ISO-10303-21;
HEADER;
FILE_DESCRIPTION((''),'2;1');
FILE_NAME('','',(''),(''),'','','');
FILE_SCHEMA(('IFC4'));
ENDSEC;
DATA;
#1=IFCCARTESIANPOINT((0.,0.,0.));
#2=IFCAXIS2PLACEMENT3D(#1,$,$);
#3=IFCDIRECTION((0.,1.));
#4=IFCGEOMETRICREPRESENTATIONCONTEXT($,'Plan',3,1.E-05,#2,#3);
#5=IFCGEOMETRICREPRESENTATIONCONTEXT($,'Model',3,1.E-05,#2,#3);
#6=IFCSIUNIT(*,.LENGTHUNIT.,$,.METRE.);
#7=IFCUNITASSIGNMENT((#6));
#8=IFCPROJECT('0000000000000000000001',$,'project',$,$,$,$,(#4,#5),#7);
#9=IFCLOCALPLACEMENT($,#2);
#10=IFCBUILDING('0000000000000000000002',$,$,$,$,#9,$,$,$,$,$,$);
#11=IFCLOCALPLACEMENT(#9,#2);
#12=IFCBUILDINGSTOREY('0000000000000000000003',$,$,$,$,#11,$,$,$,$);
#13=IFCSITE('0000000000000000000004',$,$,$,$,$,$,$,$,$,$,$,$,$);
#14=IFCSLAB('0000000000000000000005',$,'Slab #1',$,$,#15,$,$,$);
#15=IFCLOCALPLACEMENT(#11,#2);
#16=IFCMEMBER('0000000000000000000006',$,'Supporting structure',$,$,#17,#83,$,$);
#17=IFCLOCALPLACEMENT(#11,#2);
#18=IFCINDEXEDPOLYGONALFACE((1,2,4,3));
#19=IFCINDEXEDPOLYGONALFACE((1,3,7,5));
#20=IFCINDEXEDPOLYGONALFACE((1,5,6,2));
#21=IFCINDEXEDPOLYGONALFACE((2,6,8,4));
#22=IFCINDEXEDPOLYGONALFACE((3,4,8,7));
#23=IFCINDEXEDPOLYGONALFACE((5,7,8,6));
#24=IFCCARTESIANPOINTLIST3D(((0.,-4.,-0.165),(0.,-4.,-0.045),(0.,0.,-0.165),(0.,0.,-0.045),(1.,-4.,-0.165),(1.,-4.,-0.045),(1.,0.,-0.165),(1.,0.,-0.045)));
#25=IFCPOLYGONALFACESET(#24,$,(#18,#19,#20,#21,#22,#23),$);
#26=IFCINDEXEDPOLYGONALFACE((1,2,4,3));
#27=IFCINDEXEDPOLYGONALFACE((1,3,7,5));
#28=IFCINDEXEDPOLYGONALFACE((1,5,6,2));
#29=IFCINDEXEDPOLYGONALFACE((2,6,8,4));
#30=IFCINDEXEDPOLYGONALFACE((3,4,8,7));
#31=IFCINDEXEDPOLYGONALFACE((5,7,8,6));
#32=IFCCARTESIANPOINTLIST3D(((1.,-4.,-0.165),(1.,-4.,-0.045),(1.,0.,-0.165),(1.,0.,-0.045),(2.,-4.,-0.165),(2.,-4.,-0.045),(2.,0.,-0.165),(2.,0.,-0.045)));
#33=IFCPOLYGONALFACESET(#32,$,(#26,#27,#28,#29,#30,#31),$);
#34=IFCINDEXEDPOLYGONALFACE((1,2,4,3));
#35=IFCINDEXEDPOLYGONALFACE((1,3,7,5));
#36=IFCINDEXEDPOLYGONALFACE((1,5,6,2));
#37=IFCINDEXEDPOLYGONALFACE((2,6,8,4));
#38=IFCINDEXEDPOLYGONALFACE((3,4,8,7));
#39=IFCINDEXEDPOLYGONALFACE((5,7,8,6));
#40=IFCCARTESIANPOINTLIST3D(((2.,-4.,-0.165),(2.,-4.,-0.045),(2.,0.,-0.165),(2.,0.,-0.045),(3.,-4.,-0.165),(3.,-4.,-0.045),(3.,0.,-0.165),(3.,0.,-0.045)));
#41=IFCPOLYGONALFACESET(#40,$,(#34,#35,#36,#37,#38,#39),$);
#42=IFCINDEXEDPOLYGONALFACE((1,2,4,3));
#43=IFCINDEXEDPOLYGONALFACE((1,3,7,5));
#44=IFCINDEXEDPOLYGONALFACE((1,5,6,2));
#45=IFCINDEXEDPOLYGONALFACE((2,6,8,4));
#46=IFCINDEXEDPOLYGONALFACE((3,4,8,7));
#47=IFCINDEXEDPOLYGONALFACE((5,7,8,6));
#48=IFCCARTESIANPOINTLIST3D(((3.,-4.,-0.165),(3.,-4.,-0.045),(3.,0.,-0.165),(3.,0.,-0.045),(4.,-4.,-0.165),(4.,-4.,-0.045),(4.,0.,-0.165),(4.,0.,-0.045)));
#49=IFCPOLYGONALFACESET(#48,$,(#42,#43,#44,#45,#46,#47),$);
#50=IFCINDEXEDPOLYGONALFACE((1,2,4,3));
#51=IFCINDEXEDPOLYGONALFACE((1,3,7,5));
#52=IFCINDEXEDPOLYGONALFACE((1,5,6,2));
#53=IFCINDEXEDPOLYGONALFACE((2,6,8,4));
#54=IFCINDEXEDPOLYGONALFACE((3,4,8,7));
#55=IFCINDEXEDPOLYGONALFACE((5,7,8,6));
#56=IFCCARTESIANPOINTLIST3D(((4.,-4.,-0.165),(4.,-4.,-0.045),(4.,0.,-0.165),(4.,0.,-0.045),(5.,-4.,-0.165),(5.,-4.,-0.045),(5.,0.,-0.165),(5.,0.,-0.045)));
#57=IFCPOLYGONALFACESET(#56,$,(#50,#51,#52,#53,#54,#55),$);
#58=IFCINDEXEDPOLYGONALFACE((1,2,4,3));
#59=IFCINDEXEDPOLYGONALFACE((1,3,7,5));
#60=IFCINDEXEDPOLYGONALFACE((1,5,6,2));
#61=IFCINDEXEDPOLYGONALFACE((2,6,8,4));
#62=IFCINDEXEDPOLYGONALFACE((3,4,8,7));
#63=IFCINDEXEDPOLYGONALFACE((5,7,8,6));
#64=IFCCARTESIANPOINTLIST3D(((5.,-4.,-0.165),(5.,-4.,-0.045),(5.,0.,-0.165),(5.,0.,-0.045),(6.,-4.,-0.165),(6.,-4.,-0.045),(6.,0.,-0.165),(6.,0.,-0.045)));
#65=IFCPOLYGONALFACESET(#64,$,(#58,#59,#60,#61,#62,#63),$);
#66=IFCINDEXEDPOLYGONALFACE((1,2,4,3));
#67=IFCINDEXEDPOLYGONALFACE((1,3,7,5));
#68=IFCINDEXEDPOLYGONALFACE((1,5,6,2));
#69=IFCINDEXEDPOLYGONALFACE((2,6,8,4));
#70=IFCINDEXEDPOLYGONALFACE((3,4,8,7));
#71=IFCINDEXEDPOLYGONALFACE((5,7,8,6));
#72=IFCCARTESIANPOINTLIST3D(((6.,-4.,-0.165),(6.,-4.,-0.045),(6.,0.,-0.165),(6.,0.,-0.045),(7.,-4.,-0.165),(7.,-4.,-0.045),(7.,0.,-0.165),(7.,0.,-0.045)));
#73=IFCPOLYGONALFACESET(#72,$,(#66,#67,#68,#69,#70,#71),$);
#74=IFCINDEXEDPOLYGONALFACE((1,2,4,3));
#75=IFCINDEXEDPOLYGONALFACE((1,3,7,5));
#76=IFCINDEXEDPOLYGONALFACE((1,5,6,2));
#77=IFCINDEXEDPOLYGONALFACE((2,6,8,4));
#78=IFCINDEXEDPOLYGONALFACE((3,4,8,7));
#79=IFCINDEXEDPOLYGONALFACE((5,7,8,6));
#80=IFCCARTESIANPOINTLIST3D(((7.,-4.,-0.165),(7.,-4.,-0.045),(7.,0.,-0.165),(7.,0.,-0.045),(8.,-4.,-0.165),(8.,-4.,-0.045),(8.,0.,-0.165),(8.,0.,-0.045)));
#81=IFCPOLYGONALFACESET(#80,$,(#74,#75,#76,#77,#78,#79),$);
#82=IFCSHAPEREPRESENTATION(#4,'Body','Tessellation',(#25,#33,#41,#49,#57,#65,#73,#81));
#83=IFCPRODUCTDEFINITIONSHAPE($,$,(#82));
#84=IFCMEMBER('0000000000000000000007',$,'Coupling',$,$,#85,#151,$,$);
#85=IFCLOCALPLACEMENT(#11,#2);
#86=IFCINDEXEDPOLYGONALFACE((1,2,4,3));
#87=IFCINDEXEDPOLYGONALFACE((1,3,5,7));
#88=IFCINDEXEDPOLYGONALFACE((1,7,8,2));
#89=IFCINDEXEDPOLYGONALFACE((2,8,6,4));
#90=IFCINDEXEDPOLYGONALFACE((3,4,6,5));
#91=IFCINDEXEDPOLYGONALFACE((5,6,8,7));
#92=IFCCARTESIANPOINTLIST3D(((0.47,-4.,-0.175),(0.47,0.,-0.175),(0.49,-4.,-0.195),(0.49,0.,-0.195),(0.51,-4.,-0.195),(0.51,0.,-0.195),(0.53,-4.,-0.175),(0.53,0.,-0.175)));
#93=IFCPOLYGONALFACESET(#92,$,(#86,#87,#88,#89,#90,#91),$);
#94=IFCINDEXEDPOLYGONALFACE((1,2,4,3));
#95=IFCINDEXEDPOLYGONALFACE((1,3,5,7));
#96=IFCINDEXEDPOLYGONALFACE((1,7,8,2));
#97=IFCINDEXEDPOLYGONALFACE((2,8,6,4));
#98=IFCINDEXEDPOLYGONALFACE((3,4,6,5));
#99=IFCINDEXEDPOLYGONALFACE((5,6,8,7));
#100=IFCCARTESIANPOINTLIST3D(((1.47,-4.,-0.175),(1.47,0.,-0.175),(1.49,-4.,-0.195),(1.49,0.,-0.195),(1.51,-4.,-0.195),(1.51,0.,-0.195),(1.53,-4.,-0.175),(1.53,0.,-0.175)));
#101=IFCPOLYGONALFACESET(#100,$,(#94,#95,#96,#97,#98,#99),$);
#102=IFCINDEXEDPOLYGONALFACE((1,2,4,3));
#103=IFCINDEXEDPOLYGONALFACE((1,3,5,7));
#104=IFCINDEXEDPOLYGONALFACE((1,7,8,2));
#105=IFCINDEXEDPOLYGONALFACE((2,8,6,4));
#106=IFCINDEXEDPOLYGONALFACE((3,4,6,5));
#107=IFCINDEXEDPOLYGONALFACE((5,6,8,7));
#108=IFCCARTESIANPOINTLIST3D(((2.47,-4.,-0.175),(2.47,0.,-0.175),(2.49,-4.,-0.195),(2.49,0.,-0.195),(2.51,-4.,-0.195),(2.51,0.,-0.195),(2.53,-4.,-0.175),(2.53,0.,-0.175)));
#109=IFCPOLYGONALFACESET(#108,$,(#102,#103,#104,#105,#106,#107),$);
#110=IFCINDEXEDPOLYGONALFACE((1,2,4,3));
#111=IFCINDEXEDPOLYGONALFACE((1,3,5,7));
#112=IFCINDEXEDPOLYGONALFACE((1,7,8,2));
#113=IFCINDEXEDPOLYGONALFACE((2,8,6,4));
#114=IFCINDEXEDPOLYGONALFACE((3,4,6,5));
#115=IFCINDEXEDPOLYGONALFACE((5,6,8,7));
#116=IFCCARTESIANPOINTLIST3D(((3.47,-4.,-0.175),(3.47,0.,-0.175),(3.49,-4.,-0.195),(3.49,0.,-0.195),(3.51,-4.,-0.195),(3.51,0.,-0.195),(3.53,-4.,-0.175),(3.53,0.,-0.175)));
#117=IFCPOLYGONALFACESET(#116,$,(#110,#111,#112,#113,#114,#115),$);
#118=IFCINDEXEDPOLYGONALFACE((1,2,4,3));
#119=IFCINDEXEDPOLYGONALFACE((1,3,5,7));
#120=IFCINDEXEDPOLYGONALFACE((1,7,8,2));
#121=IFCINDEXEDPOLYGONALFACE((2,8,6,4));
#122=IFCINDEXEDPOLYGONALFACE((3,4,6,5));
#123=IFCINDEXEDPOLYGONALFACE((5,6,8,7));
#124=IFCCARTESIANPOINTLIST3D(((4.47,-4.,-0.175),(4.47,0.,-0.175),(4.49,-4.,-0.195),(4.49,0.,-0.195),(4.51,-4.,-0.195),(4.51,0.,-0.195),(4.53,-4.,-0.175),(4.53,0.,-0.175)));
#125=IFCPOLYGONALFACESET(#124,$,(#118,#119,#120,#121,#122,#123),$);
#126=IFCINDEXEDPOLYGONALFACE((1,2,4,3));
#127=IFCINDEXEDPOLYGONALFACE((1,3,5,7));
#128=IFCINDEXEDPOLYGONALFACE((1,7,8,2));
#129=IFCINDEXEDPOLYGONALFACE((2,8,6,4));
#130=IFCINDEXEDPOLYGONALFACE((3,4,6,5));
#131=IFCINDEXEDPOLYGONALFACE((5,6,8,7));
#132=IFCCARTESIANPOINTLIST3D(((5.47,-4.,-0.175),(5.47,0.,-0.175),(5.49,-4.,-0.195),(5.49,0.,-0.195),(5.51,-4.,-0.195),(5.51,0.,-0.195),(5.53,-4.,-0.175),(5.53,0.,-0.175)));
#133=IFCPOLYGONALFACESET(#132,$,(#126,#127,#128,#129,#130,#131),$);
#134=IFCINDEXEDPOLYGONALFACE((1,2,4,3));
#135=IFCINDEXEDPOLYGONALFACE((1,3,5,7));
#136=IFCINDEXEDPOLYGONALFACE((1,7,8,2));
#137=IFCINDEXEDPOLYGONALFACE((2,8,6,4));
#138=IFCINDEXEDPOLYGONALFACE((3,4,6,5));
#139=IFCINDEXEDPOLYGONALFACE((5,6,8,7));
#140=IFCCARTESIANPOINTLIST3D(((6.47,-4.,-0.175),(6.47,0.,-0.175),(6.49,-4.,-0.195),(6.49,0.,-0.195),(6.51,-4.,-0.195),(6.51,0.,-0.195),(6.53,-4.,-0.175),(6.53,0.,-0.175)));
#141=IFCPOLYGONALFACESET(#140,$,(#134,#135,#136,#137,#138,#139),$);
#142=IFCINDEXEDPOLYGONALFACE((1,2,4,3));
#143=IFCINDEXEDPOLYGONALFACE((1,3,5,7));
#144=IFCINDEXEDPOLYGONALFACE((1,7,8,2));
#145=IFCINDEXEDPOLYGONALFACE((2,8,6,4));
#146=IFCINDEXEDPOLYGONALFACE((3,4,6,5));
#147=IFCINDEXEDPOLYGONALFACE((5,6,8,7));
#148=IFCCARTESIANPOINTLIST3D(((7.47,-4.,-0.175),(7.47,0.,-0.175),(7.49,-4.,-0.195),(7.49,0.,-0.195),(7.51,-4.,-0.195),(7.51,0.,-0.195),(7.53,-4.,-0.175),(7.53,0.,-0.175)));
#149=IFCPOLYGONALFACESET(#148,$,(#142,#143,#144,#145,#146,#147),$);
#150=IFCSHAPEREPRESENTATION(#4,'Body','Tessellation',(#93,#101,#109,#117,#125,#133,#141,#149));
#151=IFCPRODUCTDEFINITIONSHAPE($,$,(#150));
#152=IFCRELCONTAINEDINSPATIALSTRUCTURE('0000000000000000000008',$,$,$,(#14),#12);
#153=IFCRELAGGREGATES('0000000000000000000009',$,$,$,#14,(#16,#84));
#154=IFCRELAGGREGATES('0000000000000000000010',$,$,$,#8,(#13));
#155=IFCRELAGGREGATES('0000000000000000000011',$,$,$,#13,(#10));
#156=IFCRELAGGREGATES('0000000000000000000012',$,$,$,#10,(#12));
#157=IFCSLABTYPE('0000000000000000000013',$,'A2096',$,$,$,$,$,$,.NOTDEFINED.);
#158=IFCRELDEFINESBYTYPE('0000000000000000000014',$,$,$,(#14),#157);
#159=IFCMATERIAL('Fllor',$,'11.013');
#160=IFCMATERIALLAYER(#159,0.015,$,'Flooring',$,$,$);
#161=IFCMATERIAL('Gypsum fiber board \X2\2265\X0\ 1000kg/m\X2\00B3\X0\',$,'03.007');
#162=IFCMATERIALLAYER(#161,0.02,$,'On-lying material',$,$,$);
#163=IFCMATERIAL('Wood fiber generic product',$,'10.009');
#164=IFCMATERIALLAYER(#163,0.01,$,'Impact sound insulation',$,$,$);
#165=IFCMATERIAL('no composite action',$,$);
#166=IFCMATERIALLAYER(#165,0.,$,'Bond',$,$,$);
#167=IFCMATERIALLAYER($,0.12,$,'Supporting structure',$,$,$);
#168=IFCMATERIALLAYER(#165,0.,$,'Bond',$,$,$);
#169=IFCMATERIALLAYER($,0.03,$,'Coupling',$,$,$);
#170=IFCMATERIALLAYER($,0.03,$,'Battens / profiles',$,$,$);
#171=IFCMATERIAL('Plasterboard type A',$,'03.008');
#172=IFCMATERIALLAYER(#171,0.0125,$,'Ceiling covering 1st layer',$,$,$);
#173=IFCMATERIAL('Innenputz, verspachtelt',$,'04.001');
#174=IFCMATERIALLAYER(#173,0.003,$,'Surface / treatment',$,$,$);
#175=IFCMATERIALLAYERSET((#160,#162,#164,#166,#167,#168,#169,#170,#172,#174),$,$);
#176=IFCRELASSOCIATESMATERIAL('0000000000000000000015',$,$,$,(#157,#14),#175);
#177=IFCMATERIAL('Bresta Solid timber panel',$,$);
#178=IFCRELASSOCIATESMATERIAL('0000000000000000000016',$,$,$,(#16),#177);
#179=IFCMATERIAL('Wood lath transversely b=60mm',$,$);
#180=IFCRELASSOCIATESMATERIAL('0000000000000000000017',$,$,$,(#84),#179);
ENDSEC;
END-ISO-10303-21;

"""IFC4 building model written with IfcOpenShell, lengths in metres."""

from ifc_helpers import new_model, si_unit, direction, frame, frame_2d, origin, place, context, project, spatial, polyline, rectangle, outline, extrude, material, layer, layer_set, type_object, element, aggregate, save


model = new_model("IFC4")

# Units and contexts
plan_context = context("Plan", 3, precision=1e-05, world=origin(), true_north=direction((0.0, 1.0)))
model_context = context("Model", 3, precision=1e-05, world=origin(), true_north=direction((0.0, 1.0)))
ifc_project = project(units=[si_unit("LENGTHUNIT", "METRE")], contexts=[plan_context, model_context])

# Site, building, storey
site = spatial("IfcSite", under=ifc_project)
building_placement = place(None, origin())
building = spatial("IfcBuilding", under=site, at=building_placement)
storey_placement = place(building_placement, origin())
storey = spatial("IfcBuildingStorey", under=building, at=storey_placement)

# Slab, members
ifc_material_1 = material(Name="Fllor", Category="11.013")
ifc_layer_1 = layer(ifc_material_1, 0.015, Name="Flooring")
ifc_material_2 = material(Name="Gypsum fiber board ≥ 1000kg/m³", Category="03.007")
ifc_layer_2 = layer(ifc_material_2, 0.02, Name="On-lying material")
ifc_material_3 = material(Name="Wood fiber generic product", Category="10.009")
ifc_layer_3 = layer(ifc_material_3, 0.01, Name="Impact sound insulation")
ifc_material_4 = material(Name="no composite action")
ifc_layer_4 = layer(ifc_material_4, 0.0, Name="Bond")
ifc_layer_5 = layer(None, 0.12, Name="Supporting structure")
ifc_layer_6 = layer(ifc_material_4, 0.0, Name="Bond")
ifc_layer_7 = layer(None, 0.03, Name="Coupling")
ifc_layer_8 = layer(None, 0.03, Name="Battens / profiles")
ifc_material_5 = material(Name="Plasterboard type A", Category="03.008")
ifc_layer_9 = layer(ifc_material_5, 0.0125, Name="Ceiling covering 1st layer")
ifc_material_6 = material(Name="Innenputz, verspachtelt", Category="04.001")
ifc_layer_10 = layer(ifc_material_6, 0.003, Name="Surface / treatment")
ifc_layer_set = layer_set([ifc_layer_1, ifc_layer_2, ifc_layer_3, ifc_layer_4, ifc_layer_5, ifc_layer_6, ifc_layer_7, ifc_layer_8, ifc_layer_9, ifc_layer_10])
slab_type = type_object("IfcSlabType", Name="A2096", PredefinedType="NOTDEFINED", material=ifc_layer_set)
slab_placement = place(None, frame((0.0, 0.0, 0.0), z_axis=(0.0, 0.0, -1.0), x_axis=(1.0, 0.0, 0.0)))
slab = element("IfcSlab", 1, at=slab_placement, inside=storey, type_object=slab_type, material=ifc_layer_set, Name="Slab #1")
ifc_material_7 = material(Name="Bresta Solid timber panel")
member_1_placement = place(slab_placement, origin())
member_1 = element("IfcMember", 2, at=member_1_placement, material=ifc_material_7, Name="Supporting structure", context=plan_context, shape_type="SweptSolid", body=[
    extrude(rectangle(XDim=1.0, YDim=0.12, at=frame_2d((0.5, 0.06), x_axis=(1.0, 0.0))), frame((0.0, 4.0, 0.045), z_axis=(0.0, -1.0, 0.0), x_axis=(1.0, 0.0, 0.0)), (0.0, 0.0, 1.0), 4.0),
    extrude(rectangle(XDim=1.0, YDim=0.12, at=frame_2d((0.5, 0.06), x_axis=(1.0, 0.0))), frame((1.0, 4.0, 0.045), z_axis=(0.0, -1.0, 0.0), x_axis=(1.0, 0.0, 0.0)), (0.0, 0.0, 1.0), 4.0),
    extrude(rectangle(XDim=1.0, YDim=0.12, at=frame_2d((0.5, 0.06), x_axis=(1.0, 0.0))), frame((2.0, 4.0, 0.045), z_axis=(0.0, -1.0, 0.0), x_axis=(1.0, 0.0, 0.0)), (0.0, 0.0, 1.0), 4.0),
    extrude(rectangle(XDim=1.0, YDim=0.12, at=frame_2d((0.5, 0.06), x_axis=(1.0, 0.0))), frame((3.0, 4.0, 0.045), z_axis=(0.0, -1.0, 0.0), x_axis=(1.0, 0.0, 0.0)), (0.0, 0.0, 1.0), 4.0),
    extrude(rectangle(XDim=1.0, YDim=0.12, at=frame_2d((0.5, 0.06), x_axis=(1.0, 0.0))), frame((4.0, 4.0, 0.045), z_axis=(0.0, -1.0, 0.0), x_axis=(1.0, 0.0, 0.0)), (0.0, 0.0, 1.0), 4.0),
    extrude(rectangle(XDim=1.0, YDim=0.12, at=frame_2d((0.5, 0.06), x_axis=(1.0, 0.0))), frame((5.0, 4.0, 0.045), z_axis=(0.0, -1.0, 0.0), x_axis=(1.0, 0.0, 0.0)), (0.0, 0.0, 1.0), 4.0),
    extrude(rectangle(XDim=1.0, YDim=0.12, at=frame_2d((0.5, 0.06), x_axis=(1.0, 0.0))), frame((6.0, 4.0, 0.045), z_axis=(0.0, -1.0, 0.0), x_axis=(1.0, 0.0, 0.0)), (0.0, 0.0, 1.0), 4.0),
    extrude(rectangle(XDim=1.0, YDim=0.12, at=frame_2d((0.5, 0.06), x_axis=(1.0, 0.0))), frame((7.0, 4.0, 0.045), z_axis=(0.0, -1.0, 0.0), x_axis=(1.0, 0.0, 0.0)), (0.0, 0.0, 1.0), 4.0),
])
ifc_material_8 = material(Name="Wood lath transversely b=60mm")
member_2_placement = place(slab_placement, origin())
member_2 = element("IfcMember", 3, at=member_2_placement, material=ifc_material_8, Name="Coupling", context=plan_context, shape_type="SweptSolid", body=[
    extrude(outline(polyline([(0.0, 0.0), (0.06, 0.0), (0.04, 0.02), (0.02, 0.02), (0.0, 0.0)])), frame((0.47, 4.0, 0.175), z_axis=(0.0, -1.0, 0.0), x_axis=(1.0, 0.0, 0.0)), (0.0, 0.0, 1.0), 4.0),
    extrude(outline(polyline([(0.0, 0.0), (0.06, 0.0), (0.04, 0.02), (0.02, 0.02), (0.0, 0.0)])), frame((1.47, 4.0, 0.175), z_axis=(0.0, -1.0, 0.0), x_axis=(1.0, 0.0, 0.0)), (0.0, 0.0, 1.0), 4.0),
    extrude(outline(polyline([(0.0, 0.0), (0.06, 0.0), (0.04, 0.02), (0.02, 0.02), (0.0, 0.0)])), frame((2.47, 4.0, 0.175), z_axis=(0.0, -1.0, 0.0), x_axis=(1.0, 0.0, 0.0)), (0.0, 0.0, 1.0), 4.0),
    extrude(outline(polyline([(0.0, 0.0), (0.06, 0.0), (0.04, 0.02), (0.02, 0.02), (0.0, 0.0)])), frame((3.47, 4.0, 0.175), z_axis=(0.0, -1.0, 0.0), x_axis=(1.0, 0.0, 0.0)), (0.0, 0.0, 1.0), 4.0),
    extrude(outline(polyline([(0.0, 0.0), (0.06, 0.0), (0.04, 0.02), (0.02, 0.02), (0.0, 0.0)])), frame((4.47, 4.0, 0.175), z_axis=(0.0, -1.0, 0.0), x_axis=(1.0, 0.0, 0.0)), (0.0, 0.0, 1.0), 4.0),
    extrude(outline(polyline([(0.0, 0.0), (0.06, 0.0), (0.04, 0.02), (0.02, 0.02), (0.0, 0.0)])), frame((5.47, 4.0, 0.175), z_axis=(0.0, -1.0, 0.0), x_axis=(1.0, 0.0, 0.0)), (0.0, 0.0, 1.0), 4.0),
    extrude(outline(polyline([(0.0, 0.0), (0.06, 0.0), (0.04, 0.02), (0.02, 0.02), (0.0, 0.0)])), frame((6.47, 4.0, 0.175), z_axis=(0.0, -1.0, 0.0), x_axis=(1.0, 0.0, 0.0)), (0.0, 0.0, 1.0), 4.0),
    extrude(outline(polyline([(0.0, 0.0), (0.06, 0.0), (0.04, 0.02), (0.02, 0.02), (0.0, 0.0)])), frame((7.47, 4.0, 0.175), z_axis=(0.0, -1.0, 0.0), x_axis=(1.0, 0.0, 0.0)), (0.0, 0.0, 1.0), 4.0),
])
aggregate(slab, [member_1, member_2])

save(model, "model.ifc")
